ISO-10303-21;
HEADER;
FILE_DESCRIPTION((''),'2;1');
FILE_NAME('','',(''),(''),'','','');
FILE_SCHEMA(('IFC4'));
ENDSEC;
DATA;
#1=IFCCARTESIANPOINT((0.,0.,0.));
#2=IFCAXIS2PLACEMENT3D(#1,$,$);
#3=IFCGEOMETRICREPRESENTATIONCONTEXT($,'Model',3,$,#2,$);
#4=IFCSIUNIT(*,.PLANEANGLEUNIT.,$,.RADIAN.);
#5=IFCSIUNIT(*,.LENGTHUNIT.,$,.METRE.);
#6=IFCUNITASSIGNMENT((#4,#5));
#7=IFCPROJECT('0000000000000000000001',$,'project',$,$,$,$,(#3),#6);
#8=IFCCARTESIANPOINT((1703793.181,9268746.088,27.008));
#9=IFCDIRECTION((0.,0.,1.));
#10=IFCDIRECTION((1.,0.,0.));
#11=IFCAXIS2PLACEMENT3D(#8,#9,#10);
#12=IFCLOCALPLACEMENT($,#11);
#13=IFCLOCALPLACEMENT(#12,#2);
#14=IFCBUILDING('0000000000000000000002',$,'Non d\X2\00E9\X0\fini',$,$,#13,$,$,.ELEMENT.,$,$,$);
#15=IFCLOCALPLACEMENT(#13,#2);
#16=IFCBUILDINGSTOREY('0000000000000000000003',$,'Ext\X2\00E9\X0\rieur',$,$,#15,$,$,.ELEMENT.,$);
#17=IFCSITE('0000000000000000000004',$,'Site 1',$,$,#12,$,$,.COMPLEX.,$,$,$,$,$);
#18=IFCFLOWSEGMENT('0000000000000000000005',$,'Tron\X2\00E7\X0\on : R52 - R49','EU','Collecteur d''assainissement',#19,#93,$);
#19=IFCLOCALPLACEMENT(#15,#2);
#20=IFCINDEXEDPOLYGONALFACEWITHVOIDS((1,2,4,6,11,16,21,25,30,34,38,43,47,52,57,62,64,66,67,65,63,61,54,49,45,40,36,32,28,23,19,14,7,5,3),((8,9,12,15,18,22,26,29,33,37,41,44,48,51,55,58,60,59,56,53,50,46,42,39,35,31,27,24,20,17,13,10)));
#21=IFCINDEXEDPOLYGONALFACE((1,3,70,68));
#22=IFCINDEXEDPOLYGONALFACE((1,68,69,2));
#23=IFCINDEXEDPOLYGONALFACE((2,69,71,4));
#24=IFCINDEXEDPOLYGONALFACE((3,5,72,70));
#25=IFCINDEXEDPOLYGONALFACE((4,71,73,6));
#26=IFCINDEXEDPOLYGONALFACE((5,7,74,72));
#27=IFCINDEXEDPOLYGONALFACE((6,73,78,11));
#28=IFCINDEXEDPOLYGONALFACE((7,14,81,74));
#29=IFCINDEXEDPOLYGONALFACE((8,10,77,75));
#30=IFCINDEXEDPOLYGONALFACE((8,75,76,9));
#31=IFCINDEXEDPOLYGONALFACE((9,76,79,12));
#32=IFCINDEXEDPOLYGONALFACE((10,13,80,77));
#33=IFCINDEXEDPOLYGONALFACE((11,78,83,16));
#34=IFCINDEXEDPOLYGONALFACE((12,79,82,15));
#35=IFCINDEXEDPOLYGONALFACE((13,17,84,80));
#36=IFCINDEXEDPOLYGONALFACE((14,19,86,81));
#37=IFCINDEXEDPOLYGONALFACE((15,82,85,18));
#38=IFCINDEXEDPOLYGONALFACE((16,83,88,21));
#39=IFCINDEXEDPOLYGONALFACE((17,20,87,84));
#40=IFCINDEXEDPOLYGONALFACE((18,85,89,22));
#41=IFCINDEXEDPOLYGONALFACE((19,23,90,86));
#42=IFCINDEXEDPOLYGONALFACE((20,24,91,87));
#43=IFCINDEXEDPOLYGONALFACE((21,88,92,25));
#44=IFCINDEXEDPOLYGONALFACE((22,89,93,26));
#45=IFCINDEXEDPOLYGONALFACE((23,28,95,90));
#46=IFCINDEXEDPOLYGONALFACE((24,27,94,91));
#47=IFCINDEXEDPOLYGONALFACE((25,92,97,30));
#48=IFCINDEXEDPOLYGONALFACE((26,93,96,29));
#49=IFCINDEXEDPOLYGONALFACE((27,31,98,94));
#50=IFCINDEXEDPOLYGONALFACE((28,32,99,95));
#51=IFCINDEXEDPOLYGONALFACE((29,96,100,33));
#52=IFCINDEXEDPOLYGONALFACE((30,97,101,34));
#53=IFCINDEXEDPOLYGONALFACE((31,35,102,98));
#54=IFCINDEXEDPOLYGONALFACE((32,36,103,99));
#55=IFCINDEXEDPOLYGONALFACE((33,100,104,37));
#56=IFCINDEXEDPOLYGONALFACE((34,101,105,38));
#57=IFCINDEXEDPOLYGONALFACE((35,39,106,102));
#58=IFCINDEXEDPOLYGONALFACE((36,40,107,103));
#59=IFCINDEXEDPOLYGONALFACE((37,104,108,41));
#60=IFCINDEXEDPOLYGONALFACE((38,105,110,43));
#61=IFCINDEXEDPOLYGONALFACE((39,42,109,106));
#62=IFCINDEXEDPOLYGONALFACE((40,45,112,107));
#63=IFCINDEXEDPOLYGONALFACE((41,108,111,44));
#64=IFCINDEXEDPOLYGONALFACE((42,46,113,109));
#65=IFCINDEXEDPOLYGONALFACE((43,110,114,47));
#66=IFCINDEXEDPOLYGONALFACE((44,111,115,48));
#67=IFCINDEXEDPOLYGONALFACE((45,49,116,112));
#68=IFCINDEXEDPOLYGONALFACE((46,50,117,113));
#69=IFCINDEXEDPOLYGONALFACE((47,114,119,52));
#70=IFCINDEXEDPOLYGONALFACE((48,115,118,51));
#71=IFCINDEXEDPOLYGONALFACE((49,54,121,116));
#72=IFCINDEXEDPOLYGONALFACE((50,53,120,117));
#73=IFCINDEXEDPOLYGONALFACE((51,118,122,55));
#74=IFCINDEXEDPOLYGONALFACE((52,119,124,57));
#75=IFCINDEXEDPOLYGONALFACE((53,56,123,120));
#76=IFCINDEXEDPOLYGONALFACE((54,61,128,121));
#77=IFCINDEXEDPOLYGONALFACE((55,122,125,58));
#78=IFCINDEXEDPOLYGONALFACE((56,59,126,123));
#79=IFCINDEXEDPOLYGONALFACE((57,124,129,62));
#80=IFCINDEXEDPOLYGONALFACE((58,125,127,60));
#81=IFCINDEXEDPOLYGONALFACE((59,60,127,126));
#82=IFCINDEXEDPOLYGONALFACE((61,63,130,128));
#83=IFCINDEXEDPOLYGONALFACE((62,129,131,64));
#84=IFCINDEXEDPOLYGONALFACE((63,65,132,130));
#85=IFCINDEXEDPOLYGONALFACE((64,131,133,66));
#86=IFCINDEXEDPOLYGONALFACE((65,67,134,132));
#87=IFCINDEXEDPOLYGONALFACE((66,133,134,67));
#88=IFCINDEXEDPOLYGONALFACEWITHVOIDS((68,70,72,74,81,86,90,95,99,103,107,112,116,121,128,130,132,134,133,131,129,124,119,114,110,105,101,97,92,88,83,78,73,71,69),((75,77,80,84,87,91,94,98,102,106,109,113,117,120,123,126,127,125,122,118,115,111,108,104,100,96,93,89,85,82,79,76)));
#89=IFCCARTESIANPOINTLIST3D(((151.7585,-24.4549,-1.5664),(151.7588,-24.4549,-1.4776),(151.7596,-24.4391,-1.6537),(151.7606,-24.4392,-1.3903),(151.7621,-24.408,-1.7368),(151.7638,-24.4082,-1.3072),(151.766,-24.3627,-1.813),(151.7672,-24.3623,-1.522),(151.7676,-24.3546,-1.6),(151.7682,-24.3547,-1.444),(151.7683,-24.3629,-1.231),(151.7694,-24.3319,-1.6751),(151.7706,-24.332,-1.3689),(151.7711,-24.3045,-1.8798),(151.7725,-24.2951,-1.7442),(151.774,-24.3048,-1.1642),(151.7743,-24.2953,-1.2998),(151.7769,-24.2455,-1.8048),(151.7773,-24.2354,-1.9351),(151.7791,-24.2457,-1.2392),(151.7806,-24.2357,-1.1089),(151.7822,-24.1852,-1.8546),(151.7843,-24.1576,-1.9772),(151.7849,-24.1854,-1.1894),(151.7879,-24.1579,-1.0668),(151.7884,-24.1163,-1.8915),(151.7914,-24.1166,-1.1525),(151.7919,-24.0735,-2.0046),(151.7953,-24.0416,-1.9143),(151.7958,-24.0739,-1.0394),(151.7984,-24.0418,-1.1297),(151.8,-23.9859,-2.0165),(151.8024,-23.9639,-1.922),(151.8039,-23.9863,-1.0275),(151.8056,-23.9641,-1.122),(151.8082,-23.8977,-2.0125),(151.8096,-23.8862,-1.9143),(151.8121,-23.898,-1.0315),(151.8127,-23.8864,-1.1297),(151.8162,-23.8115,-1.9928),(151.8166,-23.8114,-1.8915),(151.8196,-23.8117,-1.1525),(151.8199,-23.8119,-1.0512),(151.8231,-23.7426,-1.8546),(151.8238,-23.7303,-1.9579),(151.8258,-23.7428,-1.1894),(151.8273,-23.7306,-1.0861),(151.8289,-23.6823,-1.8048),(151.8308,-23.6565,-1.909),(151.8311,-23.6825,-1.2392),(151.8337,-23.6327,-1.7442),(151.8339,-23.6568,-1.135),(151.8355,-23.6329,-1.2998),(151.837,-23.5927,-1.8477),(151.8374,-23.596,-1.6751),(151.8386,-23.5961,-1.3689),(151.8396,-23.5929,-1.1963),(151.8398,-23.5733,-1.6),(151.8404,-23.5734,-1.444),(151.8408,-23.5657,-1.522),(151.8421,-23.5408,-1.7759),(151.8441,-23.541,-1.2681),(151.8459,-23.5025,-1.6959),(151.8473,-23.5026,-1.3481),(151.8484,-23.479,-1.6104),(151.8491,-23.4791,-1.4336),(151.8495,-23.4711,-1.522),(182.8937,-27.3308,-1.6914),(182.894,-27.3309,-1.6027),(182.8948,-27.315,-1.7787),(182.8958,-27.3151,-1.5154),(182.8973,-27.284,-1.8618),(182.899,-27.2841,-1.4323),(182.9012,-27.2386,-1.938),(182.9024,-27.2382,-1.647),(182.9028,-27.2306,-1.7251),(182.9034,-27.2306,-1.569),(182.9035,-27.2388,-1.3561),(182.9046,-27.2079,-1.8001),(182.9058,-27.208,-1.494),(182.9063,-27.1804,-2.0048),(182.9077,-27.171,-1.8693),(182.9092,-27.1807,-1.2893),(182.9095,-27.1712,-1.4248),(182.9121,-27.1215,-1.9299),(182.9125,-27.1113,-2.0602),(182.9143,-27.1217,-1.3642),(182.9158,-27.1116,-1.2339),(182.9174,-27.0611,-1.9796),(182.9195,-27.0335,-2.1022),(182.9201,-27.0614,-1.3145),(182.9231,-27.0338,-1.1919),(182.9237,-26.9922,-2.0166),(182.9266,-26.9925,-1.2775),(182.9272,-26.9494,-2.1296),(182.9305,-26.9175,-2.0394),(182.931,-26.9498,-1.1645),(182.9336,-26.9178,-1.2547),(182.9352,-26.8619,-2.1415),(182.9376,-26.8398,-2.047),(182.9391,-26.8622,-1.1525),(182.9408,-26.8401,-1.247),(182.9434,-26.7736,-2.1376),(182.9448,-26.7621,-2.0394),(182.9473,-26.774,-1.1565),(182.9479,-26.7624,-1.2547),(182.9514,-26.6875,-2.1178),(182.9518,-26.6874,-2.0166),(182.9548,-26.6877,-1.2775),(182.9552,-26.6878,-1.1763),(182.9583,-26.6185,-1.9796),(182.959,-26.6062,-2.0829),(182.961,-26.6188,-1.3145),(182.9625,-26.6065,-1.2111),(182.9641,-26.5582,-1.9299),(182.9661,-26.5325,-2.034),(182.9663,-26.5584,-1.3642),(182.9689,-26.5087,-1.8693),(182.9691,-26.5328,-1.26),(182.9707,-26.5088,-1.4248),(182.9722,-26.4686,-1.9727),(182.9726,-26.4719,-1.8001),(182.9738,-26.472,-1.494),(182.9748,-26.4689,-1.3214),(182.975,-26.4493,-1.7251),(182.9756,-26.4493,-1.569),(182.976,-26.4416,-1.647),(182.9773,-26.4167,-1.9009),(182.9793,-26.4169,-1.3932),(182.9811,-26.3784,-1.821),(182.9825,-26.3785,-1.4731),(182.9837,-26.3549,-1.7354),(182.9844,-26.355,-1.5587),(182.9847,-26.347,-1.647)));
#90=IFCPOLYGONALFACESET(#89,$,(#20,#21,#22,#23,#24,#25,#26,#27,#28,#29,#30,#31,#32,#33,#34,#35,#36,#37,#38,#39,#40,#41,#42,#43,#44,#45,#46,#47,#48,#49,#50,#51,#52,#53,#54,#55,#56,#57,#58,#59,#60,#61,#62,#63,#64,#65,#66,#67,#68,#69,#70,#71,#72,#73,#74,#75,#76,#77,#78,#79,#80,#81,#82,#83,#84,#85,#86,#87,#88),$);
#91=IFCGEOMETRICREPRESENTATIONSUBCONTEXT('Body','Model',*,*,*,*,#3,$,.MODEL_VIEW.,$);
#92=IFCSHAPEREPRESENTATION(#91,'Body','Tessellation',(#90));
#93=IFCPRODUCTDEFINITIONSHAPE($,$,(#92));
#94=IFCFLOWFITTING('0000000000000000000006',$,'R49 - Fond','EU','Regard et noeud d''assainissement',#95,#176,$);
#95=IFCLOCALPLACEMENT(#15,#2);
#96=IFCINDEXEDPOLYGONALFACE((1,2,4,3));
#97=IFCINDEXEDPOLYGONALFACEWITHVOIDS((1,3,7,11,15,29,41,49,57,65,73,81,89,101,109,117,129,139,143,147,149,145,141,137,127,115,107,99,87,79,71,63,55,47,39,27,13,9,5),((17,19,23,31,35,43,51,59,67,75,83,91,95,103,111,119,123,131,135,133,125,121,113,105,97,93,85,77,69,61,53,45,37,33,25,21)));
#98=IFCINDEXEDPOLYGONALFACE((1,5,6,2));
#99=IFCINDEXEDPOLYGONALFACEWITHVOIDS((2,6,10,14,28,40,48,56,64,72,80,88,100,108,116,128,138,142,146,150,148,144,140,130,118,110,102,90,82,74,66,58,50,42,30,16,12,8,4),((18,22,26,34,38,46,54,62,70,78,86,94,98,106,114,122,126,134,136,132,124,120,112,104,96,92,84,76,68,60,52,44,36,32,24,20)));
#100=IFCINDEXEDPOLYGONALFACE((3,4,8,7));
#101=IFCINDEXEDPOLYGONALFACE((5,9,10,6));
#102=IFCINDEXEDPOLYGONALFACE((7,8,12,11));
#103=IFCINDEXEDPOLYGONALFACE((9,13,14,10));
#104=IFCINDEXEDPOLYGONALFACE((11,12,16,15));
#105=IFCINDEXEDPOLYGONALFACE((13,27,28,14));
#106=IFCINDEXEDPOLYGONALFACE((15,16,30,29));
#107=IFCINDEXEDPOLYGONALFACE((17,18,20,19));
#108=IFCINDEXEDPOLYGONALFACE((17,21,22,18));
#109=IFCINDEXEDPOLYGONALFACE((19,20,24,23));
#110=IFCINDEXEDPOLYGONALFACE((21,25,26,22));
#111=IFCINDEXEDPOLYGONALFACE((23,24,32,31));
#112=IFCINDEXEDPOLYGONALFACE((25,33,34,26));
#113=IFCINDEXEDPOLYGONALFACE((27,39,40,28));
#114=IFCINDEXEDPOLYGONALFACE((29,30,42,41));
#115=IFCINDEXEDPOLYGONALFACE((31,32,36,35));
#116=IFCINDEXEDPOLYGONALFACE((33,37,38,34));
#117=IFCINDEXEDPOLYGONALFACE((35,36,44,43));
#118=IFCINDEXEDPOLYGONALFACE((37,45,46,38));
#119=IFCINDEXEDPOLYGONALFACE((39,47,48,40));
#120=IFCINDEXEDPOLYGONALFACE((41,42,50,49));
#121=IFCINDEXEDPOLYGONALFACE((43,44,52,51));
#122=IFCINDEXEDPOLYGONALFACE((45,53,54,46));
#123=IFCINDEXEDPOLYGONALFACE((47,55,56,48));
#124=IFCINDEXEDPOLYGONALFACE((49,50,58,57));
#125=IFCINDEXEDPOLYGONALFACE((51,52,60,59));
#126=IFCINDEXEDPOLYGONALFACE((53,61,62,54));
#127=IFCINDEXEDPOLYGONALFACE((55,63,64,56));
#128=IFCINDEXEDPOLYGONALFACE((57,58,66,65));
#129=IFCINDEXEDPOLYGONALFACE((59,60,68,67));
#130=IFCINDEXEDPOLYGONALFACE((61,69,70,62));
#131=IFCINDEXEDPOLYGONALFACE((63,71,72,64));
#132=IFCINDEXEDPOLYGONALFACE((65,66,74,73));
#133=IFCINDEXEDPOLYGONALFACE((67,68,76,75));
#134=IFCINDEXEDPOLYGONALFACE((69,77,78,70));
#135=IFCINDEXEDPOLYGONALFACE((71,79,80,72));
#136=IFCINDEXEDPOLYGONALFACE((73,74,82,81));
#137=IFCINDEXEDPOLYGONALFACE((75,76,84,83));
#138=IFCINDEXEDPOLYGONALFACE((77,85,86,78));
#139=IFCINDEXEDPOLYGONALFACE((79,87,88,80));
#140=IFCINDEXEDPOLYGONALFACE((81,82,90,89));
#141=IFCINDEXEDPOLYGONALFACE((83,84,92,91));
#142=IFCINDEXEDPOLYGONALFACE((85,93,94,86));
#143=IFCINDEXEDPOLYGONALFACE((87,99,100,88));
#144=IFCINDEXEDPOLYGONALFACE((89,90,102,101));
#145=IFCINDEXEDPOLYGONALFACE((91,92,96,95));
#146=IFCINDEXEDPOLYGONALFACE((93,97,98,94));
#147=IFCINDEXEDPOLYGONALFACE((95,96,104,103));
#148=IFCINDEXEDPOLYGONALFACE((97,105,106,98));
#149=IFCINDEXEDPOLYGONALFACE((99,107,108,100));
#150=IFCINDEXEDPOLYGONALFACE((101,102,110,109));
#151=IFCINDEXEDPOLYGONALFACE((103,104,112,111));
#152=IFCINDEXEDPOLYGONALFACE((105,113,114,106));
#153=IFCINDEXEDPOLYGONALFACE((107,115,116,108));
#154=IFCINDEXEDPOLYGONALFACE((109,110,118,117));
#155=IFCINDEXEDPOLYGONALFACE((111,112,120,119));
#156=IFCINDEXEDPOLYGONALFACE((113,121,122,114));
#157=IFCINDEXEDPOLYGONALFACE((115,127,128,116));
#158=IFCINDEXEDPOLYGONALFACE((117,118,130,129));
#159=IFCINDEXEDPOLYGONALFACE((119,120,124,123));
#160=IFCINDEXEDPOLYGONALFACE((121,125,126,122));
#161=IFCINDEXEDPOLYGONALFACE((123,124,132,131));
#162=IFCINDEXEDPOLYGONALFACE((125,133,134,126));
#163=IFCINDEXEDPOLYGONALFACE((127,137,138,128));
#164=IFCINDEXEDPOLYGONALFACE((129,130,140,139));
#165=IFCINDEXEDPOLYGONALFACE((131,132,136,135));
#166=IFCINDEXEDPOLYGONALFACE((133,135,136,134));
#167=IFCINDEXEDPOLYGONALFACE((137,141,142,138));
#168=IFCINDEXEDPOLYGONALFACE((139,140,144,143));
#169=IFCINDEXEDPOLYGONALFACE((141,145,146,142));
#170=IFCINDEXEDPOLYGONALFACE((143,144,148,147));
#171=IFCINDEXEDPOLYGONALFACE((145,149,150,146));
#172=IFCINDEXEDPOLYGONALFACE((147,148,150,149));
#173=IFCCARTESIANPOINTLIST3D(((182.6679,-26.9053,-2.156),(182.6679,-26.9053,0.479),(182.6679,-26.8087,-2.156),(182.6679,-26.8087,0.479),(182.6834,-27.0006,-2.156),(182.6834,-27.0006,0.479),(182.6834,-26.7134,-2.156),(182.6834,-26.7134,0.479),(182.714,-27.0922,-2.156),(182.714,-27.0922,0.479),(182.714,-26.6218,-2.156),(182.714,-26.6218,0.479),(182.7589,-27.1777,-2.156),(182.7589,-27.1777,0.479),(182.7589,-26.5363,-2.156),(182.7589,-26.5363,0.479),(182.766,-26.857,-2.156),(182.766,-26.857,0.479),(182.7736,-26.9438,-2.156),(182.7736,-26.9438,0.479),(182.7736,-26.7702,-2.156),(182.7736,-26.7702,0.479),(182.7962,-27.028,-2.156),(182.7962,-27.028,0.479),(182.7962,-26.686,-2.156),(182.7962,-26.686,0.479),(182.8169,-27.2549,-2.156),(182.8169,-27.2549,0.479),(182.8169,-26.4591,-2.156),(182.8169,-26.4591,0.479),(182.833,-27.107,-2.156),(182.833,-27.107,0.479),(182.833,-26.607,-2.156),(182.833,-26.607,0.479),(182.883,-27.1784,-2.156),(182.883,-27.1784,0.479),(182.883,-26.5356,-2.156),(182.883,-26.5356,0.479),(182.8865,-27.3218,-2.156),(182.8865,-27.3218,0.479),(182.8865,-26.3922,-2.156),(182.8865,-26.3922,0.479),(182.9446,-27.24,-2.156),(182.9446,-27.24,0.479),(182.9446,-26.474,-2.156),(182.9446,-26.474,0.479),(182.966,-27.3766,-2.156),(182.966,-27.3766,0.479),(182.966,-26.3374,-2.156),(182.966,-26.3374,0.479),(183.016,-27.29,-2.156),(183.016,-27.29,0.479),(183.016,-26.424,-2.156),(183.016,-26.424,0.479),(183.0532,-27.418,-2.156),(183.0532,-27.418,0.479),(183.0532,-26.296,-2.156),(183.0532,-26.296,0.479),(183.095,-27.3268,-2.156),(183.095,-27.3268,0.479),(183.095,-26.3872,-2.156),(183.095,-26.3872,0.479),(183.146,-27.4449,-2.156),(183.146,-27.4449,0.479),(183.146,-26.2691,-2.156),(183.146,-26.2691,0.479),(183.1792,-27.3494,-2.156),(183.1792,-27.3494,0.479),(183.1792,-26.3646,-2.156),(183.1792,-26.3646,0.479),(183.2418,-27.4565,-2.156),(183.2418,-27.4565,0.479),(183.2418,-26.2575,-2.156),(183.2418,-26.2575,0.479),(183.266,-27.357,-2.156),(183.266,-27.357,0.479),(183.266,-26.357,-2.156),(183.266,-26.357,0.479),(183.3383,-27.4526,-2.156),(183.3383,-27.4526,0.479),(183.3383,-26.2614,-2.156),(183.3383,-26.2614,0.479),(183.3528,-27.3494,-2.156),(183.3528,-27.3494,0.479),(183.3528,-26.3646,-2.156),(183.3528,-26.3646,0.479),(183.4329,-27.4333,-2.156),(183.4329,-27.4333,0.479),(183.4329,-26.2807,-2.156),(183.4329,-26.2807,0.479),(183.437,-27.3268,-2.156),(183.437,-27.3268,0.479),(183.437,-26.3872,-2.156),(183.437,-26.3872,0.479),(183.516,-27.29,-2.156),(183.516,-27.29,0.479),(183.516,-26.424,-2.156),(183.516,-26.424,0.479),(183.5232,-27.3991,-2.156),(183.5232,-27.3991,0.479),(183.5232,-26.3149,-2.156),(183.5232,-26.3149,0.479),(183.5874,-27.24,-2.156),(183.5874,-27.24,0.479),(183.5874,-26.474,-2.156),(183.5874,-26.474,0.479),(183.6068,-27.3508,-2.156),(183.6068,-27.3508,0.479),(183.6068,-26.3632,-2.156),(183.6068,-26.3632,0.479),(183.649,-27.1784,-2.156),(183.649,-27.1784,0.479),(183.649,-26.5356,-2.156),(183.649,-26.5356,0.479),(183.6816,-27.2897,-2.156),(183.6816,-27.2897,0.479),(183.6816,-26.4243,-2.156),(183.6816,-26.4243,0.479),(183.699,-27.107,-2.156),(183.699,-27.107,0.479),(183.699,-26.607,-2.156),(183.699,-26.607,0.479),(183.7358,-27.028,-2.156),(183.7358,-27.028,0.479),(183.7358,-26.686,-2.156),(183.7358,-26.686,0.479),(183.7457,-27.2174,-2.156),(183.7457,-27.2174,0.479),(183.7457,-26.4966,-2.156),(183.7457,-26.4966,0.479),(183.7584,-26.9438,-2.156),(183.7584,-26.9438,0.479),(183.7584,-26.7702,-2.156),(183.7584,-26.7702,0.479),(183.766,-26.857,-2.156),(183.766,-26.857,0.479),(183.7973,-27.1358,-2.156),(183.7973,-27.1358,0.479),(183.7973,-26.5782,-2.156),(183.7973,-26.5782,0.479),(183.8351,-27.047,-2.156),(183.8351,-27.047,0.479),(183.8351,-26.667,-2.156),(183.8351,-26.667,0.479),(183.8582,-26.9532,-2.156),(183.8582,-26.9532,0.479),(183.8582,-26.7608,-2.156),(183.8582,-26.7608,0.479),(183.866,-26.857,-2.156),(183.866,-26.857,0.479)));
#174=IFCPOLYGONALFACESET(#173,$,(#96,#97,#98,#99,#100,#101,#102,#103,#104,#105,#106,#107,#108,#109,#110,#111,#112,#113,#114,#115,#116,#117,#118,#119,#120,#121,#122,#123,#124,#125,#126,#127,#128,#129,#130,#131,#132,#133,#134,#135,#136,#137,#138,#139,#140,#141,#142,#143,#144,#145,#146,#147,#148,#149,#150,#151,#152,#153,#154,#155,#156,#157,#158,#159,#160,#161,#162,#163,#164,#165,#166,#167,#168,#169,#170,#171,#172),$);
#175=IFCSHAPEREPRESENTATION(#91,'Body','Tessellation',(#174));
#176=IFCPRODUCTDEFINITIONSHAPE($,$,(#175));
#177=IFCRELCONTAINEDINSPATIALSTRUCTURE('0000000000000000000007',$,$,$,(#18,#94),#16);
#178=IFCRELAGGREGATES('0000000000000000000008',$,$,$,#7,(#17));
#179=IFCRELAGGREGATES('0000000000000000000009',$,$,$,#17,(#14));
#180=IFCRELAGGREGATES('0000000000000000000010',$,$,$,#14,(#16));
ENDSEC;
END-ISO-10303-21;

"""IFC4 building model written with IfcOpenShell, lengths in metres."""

from ifc_helpers import new_model, si_unit, frame, origin, origin_2d, place, context, subcontext, project, spatial, hollow_circle, extrude, element, save


model = new_model("IFC4")

# Units and contexts
model_context = context("Model", 3, world=origin())
body_context = subcontext(model_context, "Body", "Model", "MODEL_VIEW")
ifc_project = project(units=[si_unit("PLANEANGLEUNIT", "RADIAN"), si_unit("LENGTHUNIT", "METRE")], contexts=[model_context])

# Site, building, storey
site_placement = place(None, frame((1703793.181, 9268746.088, 27.008), z_axis=(0.0, 0.0, 1.0), x_axis=(1.0, 0.0, 0.0)))
site = spatial("IfcSite", under=ifc_project, at=site_placement, Name="Site 1", CompositionType="COMPLEX")
building_placement = place(site_placement, origin())
building = spatial("IfcBuilding", under=site, at=building_placement, Name="Non défini", CompositionType="ELEMENT")
storey_placement = place(building_placement, origin())
storey = spatial("IfcBuildingStorey", under=building, at=storey_placement, Name="Extérieur", CompositionType="ELEMENT")

# Flow segment
flow_segment_1_placement = place(storey_placement, origin())
element("IfcFlowSegment", 1, at=flow_segment_1_placement, inside=storey, Name="Tronçon : R52 - R49", Description="EU", ObjectType="Collecteur d'assainissement", context=body_context, shape_type="SweptSolid", body=[
    extrude(hollow_circle(Radius=0.495, WallThickness=0.095, at=origin_2d()), frame((151.804, -23.964, -1.522), z_axis=(0.996, -0.092, -0.004), x_axis=(0.092, 0.996, 0.0)), (0.0, 0.0, 1.0), 31.268),
])

# Flow fitting
flow_fitting_1_placement = place(storey_placement, origin())
element("IfcFlowFitting", 2, at=flow_fitting_1_placement, inside=storey, Name="R49 - Fond", Description="EU", ObjectType="Regard et noeud d'assainissement", context=body_context, shape_type="SweptSolid", body=[
    extrude(hollow_circle(Radius=0.6, WallThickness=0.1, at=origin_2d()), frame((183.266, -26.857, -2.156), z_axis=(0.0, 0.0, 1.0), x_axis=(1.0, 0.0, 0.0)), (0.0, 0.0, 1.0), 2.635),
])

save(model, "model.ifc")
